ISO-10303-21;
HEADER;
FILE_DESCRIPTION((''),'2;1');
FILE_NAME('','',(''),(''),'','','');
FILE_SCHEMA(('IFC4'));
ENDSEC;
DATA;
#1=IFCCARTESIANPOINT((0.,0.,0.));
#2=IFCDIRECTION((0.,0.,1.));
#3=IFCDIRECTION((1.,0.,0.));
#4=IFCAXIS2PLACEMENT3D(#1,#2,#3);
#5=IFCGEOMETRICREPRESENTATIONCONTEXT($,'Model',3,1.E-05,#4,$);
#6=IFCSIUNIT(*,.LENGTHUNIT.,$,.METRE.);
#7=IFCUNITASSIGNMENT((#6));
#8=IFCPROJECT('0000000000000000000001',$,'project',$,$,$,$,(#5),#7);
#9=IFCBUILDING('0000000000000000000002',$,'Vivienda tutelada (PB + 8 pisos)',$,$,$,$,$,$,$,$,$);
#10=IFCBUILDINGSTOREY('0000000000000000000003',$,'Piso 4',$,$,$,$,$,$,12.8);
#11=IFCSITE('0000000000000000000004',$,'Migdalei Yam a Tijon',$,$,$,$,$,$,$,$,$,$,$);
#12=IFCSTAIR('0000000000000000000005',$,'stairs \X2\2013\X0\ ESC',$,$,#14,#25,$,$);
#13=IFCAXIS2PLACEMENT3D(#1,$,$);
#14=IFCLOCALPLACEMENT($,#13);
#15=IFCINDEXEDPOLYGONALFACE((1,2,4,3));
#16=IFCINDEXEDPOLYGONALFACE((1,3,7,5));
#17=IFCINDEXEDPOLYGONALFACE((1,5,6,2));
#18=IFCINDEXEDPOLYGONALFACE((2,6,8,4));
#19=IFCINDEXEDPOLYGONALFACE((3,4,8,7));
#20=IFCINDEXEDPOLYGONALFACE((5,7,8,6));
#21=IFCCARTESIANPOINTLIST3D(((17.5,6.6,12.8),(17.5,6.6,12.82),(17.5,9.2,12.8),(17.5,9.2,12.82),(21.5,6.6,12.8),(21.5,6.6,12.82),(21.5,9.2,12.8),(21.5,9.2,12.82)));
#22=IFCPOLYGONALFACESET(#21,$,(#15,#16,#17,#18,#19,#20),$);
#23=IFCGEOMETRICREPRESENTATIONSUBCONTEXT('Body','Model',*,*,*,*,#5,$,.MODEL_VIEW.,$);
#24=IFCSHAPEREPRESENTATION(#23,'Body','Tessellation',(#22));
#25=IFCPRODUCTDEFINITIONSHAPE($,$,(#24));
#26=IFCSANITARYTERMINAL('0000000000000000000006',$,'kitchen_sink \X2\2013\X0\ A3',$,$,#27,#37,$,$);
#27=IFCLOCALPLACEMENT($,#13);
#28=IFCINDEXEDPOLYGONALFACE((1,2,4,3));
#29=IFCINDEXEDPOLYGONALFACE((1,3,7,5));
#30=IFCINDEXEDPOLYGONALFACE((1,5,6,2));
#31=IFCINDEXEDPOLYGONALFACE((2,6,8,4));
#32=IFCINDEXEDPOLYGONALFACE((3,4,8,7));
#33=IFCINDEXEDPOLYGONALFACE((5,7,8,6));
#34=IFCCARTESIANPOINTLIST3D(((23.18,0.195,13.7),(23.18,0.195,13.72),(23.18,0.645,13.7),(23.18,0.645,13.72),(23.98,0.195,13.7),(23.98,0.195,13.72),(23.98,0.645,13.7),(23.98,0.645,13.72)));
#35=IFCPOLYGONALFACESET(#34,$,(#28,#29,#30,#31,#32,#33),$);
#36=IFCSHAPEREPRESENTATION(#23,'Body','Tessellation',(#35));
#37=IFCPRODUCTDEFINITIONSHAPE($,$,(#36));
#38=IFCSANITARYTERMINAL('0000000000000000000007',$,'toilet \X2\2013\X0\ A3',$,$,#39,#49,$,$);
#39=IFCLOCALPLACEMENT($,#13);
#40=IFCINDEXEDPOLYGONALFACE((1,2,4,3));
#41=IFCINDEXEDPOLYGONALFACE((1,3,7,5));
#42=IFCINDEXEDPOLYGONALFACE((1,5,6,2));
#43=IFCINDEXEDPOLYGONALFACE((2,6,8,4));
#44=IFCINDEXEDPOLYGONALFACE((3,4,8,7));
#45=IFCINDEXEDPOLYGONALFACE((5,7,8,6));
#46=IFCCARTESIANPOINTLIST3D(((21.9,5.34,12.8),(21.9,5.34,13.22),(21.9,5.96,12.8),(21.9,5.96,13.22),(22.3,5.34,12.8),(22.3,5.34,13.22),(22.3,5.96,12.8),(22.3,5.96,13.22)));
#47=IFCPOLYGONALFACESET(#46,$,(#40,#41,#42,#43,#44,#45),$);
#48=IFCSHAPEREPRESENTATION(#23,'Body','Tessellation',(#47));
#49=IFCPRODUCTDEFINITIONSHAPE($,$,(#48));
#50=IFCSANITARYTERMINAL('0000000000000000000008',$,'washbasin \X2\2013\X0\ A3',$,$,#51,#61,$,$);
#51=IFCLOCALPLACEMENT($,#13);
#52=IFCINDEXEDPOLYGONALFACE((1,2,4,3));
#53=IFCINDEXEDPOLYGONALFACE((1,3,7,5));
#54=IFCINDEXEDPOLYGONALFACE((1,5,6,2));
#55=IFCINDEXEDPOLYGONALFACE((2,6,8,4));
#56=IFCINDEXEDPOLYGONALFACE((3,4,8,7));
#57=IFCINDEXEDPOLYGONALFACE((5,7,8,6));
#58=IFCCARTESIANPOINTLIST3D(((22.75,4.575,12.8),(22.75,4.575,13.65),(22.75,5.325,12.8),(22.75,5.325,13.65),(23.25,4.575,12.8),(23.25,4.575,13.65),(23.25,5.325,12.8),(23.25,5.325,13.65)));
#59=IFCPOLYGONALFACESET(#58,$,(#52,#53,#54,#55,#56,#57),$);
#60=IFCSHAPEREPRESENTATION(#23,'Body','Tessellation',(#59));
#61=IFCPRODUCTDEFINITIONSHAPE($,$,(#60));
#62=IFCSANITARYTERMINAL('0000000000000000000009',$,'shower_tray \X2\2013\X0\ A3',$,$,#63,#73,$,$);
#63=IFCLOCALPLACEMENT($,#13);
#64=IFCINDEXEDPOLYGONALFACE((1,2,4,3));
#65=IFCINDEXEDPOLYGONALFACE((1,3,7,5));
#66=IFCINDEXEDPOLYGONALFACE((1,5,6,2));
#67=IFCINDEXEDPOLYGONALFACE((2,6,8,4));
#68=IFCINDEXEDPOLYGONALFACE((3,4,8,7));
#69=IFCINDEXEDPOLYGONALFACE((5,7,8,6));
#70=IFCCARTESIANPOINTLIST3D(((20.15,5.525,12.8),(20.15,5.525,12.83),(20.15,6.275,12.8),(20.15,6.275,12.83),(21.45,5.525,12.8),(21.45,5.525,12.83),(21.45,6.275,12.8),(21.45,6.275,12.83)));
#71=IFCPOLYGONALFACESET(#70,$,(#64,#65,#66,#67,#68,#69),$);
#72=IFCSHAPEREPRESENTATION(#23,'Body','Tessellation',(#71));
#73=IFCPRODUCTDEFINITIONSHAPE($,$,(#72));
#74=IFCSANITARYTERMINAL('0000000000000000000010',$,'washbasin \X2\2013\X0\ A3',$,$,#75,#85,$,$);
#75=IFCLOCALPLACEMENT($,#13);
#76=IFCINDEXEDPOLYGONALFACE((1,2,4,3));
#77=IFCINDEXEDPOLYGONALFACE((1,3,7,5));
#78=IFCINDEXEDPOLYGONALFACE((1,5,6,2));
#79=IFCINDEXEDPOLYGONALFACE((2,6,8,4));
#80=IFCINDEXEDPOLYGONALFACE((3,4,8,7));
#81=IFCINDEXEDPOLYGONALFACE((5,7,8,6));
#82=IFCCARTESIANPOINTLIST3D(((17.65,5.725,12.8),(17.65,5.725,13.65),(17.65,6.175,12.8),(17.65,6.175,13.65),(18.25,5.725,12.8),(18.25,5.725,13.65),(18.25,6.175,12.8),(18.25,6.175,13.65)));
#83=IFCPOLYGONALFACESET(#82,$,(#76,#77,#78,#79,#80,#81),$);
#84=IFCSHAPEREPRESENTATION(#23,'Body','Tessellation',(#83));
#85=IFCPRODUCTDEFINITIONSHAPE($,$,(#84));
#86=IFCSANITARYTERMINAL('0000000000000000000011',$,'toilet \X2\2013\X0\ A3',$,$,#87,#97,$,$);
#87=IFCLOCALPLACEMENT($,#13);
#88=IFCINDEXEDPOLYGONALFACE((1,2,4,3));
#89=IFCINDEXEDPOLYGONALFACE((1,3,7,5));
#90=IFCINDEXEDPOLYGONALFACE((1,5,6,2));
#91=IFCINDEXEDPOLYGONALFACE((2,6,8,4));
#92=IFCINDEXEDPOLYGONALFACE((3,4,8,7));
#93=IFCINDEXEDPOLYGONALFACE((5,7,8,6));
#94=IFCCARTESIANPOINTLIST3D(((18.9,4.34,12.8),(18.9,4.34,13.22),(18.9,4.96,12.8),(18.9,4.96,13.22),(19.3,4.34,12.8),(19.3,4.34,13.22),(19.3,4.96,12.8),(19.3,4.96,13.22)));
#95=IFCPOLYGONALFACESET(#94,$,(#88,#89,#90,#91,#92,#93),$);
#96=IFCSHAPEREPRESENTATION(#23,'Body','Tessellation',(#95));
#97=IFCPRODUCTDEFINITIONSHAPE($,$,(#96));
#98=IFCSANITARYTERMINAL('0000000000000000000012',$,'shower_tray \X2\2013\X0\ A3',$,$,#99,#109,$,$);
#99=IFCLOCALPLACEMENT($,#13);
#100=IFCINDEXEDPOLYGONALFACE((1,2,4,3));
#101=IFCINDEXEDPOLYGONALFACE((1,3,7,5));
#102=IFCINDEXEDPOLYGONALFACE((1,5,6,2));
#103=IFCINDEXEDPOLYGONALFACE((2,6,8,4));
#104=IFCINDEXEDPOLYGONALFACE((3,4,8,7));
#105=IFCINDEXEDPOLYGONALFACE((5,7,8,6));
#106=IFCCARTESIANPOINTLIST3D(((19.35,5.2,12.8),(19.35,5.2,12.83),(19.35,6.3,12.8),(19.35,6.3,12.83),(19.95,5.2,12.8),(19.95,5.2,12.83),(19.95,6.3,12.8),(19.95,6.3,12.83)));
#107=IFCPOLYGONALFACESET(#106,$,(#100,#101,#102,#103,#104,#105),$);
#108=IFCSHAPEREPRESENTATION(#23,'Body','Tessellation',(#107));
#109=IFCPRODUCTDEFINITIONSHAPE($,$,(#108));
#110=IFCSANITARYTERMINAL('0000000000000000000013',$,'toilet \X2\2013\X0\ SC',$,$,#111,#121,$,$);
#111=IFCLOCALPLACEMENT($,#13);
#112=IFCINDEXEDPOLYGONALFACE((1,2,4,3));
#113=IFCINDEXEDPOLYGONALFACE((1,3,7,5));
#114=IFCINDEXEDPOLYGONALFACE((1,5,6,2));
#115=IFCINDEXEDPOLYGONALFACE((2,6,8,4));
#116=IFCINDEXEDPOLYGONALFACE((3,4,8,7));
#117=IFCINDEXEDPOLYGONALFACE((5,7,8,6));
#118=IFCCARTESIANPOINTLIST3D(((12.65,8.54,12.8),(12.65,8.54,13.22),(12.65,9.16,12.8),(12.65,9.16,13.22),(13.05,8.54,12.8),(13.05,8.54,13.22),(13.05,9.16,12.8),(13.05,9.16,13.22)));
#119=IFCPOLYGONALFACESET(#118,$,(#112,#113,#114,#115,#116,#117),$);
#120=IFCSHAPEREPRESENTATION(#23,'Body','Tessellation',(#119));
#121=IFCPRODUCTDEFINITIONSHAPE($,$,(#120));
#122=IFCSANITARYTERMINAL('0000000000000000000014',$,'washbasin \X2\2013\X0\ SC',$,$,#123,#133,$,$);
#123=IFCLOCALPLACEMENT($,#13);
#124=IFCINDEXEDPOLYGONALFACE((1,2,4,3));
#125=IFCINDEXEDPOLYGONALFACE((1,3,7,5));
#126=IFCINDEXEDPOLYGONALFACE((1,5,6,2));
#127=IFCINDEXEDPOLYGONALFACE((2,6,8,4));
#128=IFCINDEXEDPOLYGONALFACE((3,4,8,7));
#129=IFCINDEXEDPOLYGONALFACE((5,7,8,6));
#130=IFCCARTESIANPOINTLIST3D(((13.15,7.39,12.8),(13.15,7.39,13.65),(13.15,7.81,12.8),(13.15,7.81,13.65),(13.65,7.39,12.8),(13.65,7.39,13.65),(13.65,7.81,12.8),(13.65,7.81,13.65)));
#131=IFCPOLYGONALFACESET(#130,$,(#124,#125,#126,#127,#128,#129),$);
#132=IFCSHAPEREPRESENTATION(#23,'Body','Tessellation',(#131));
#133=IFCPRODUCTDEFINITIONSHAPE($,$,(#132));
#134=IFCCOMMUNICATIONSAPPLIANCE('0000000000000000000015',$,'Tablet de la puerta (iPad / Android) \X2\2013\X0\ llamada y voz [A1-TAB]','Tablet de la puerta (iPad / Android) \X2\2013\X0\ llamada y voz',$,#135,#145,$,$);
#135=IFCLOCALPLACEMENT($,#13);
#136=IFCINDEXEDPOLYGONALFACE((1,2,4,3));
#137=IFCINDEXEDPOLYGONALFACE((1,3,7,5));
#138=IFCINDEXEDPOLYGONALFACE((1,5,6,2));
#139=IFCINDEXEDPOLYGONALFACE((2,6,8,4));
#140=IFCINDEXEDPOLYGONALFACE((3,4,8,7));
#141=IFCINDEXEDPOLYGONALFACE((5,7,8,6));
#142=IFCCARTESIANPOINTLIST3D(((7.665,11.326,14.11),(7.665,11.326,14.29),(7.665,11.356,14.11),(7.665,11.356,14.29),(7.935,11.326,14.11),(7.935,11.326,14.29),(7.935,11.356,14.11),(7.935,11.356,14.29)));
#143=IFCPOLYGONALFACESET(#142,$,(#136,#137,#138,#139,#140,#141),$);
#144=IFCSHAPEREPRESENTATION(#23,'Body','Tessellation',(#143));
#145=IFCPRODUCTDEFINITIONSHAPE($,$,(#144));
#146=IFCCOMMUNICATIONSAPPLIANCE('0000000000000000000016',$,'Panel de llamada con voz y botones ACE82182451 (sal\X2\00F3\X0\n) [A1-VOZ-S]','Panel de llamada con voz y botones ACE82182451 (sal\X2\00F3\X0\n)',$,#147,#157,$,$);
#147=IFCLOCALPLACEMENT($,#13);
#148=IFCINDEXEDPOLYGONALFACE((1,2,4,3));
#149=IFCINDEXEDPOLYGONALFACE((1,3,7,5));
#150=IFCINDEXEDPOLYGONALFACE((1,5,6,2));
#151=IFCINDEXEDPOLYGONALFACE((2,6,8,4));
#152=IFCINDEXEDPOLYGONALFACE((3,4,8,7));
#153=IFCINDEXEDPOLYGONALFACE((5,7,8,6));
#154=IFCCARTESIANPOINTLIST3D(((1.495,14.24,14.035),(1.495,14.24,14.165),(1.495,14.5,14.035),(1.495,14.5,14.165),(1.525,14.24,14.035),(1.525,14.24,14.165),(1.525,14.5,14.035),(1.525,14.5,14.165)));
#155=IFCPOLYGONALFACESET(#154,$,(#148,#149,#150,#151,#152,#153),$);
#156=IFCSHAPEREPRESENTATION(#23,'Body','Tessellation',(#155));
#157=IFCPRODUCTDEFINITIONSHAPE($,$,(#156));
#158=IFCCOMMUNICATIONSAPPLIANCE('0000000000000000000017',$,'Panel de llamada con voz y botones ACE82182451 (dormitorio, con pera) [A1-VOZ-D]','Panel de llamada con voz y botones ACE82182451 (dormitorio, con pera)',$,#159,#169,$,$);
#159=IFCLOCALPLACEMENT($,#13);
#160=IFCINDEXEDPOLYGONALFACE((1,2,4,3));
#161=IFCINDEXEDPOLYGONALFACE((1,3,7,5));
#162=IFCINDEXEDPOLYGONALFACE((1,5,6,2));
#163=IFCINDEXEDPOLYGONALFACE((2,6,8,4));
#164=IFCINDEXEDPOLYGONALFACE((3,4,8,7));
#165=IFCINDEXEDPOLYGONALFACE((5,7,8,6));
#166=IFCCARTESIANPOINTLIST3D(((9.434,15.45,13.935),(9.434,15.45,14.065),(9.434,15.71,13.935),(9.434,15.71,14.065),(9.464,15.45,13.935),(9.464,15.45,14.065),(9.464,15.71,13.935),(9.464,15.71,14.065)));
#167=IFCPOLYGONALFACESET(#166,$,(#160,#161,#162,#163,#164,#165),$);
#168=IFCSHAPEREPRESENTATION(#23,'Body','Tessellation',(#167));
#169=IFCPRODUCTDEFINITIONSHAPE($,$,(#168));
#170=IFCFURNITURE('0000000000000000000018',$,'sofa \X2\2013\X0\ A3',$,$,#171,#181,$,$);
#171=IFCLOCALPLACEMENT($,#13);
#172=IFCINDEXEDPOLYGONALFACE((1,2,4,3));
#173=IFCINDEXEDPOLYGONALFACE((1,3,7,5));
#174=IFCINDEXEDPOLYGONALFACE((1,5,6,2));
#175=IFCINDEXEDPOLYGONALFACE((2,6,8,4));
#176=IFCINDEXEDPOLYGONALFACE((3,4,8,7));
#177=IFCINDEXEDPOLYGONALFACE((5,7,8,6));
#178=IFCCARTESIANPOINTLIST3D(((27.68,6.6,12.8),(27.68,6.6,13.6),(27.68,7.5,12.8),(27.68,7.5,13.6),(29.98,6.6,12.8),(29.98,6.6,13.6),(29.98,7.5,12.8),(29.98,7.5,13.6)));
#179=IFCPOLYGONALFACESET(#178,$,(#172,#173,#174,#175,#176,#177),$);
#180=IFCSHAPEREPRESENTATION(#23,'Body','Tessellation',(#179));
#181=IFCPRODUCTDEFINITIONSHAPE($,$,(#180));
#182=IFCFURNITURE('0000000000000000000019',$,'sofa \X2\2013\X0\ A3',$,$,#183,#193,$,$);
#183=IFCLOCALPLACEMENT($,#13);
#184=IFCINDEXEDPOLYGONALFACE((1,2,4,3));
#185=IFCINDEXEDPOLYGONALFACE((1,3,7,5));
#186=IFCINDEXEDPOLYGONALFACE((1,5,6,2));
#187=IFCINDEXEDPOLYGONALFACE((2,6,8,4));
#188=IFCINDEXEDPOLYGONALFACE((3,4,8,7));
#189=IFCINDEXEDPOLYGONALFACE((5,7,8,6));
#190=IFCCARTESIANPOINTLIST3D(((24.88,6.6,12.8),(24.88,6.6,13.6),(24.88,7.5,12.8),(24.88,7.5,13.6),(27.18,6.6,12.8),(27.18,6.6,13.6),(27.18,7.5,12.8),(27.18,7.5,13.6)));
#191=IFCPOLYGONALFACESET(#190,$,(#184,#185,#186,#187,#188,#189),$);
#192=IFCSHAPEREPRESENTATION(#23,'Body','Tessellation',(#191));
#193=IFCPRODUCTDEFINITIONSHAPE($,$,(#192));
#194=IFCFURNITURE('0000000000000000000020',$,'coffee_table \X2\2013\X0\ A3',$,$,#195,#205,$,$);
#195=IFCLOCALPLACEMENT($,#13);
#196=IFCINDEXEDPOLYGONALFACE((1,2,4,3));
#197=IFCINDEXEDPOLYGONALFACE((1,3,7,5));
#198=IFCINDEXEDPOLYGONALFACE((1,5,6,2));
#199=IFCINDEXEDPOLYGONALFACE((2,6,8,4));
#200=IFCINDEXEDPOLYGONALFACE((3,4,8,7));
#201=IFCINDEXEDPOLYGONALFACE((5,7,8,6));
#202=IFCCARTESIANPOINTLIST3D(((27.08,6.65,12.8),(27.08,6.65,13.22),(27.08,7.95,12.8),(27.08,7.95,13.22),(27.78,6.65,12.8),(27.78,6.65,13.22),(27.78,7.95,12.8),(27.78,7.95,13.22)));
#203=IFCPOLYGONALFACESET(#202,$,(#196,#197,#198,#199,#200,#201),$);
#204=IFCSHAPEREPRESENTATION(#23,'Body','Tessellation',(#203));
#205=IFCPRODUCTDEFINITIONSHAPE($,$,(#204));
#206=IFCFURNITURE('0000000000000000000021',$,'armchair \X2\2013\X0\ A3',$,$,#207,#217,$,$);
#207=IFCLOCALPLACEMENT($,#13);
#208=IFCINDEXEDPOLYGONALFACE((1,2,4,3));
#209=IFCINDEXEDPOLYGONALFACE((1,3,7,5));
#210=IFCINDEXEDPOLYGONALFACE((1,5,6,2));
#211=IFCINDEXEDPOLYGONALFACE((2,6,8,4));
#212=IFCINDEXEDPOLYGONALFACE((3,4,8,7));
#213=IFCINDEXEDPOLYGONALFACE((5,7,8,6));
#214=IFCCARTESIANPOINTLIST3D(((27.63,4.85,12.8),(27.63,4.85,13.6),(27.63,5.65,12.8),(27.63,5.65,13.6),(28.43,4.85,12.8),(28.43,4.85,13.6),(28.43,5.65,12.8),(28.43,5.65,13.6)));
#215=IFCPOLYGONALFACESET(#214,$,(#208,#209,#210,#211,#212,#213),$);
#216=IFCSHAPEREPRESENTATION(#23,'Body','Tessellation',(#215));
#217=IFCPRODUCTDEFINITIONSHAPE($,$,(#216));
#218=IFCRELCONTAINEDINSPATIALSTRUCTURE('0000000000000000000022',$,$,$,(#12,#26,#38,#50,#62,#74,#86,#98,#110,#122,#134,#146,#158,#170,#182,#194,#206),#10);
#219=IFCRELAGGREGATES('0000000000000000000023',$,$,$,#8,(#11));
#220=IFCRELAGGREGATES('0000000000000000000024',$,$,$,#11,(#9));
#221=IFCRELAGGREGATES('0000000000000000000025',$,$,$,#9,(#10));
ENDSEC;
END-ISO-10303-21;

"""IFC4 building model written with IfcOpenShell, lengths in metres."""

from ifc_helpers import new_model, si_unit, frame, origin_with_axes, context, subcontext, project, spatial, line, indexed_curve, outline, extrude, element, save


model = new_model("IFC4")

# Units and contexts
model_context = context("Model", 3, precision=1e-05, world=origin_with_axes())
body_context = subcontext(model_context, "Body", "Model", "MODEL_VIEW")
ifc_project = project(units=[si_unit("LENGTHUNIT", "METRE")], contexts=[model_context])

# Site, building, storey
site = spatial("IfcSite", under=ifc_project, Name="Migdalei Yam a Tijon")
building = spatial("IfcBuilding", under=site, Name="Vivienda tutelada (PB + 8 pisos)")
storey = spatial("IfcBuildingStorey", under=building, Name="Piso 4", Elevation=12.8)

# Stair
element("IfcStair", 1, inside=storey, Name="stairs – ESC", context=body_context, shape_type="SweptSolid", body=[
    extrude(outline(indexed_curve([(0.0, 0.0), (4.0, 0.0), (4.0, 2.6), (0.0, 2.6)], segments=[line(1, 2, 3, 4, 1)])), frame((17.5, 6.6, 12.8), z_axis=(0.0, 0.0, 1.0), x_axis=(1.0, 0.0, 0.0)), (0.0, 0.0, 1.0), 0.02),
])

# Sanitary terminals
element("IfcSanitaryTerminal", 2, inside=storey, Name="kitchen_sink – A3", context=body_context, shape_type="SweptSolid", body=[
    extrude(outline(indexed_curve([(0.0, 0.0), (0.8, 0.0), (0.8, 0.45), (0.0, 0.45)], segments=[line(1, 2, 3, 4, 1)])), frame((23.18, 0.195, 13.7), z_axis=(0.0, 0.0, 1.0), x_axis=(1.0, 0.0, 0.0)), (0.0, 0.0, 1.0), 0.02),
])
element("IfcSanitaryTerminal", 3, inside=storey, Name="toilet – A3", context=body_context, shape_type="SweptSolid", body=[
    extrude(outline(indexed_curve([(0.0, 0.0), (0.4, 0.0), (0.4, 0.62), (0.0, 0.62)], segments=[line(1, 2, 3, 4, 1)])), frame((21.9, 5.34, 12.8), z_axis=(0.0, 0.0, 1.0), x_axis=(1.0, 0.0, 0.0)), (0.0, 0.0, 1.0), 0.42),
])
element("IfcSanitaryTerminal", 4, inside=storey, Name="washbasin – A3", context=body_context, shape_type="SweptSolid", body=[
    extrude(outline(indexed_curve([(0.0, 0.0), (0.5, 0.0), (0.5, 0.75), (0.0, 0.75)], segments=[line(1, 2, 3, 4, 1)])), frame((22.75, 4.575, 12.8), z_axis=(0.0, 0.0, 1.0), x_axis=(1.0, 0.0, 0.0)), (0.0, 0.0, 1.0), 0.85),
])
element("IfcSanitaryTerminal", 5, inside=storey, Name="shower_tray – A3", context=body_context, shape_type="SweptSolid", body=[
    extrude(outline(indexed_curve([(0.0, 0.0), (1.3, 0.0), (1.3, 0.75), (0.0, 0.75)], segments=[line(1, 2, 3, 4, 1)])), frame((20.15, 5.525, 12.8), z_axis=(0.0, 0.0, 1.0), x_axis=(1.0, 0.0, 0.0)), (0.0, 0.0, 1.0), 0.03),
])
element("IfcSanitaryTerminal", 6, inside=storey, Name="washbasin – A3", context=body_context, shape_type="SweptSolid", body=[
    extrude(outline(indexed_curve([(0.0, 0.0), (0.6, 0.0), (0.6, 0.45), (0.0, 0.45)], segments=[line(1, 2, 3, 4, 1)])), frame((17.65, 5.725, 12.8), z_axis=(0.0, 0.0, 1.0), x_axis=(1.0, 0.0, 0.0)), (0.0, 0.0, 1.0), 0.85),
])
element("IfcSanitaryTerminal", 7, inside=storey, Name="toilet – A3", context=body_context, shape_type="SweptSolid", body=[
    extrude(outline(indexed_curve([(0.0, 0.0), (0.4, 0.0), (0.4, 0.62), (0.0, 0.62)], segments=[line(1, 2, 3, 4, 1)])), frame((18.9, 4.34, 12.8), z_axis=(0.0, 0.0, 1.0), x_axis=(1.0, 0.0, 0.0)), (0.0, 0.0, 1.0), 0.42),
])
element("IfcSanitaryTerminal", 8, inside=storey, Name="shower_tray – A3", context=body_context, shape_type="SweptSolid", body=[
    extrude(outline(indexed_curve([(0.0, 0.0), (0.6, 0.0), (0.6, 1.1), (0.0, 1.1)], segments=[line(1, 2, 3, 4, 1)])), frame((19.35, 5.2, 12.8), z_axis=(0.0, 0.0, 1.0), x_axis=(1.0, 0.0, 0.0)), (0.0, 0.0, 1.0), 0.03),
])
element("IfcSanitaryTerminal", 9, inside=storey, Name="toilet – SC", context=body_context, shape_type="SweptSolid", body=[
    extrude(outline(indexed_curve([(0.0, 0.0), (0.4, 0.0), (0.4, 0.62), (0.0, 0.62)], segments=[line(1, 2, 3, 4, 1)])), frame((12.65, 8.54, 12.8), z_axis=(0.0, 0.0, 1.0), x_axis=(1.0, 0.0, 0.0)), (0.0, 0.0, 1.0), 0.42),
])
element("IfcSanitaryTerminal", 10, inside=storey, Name="washbasin – SC", context=body_context, shape_type="SweptSolid", body=[
    extrude(outline(indexed_curve([(0.0, 0.0), (0.5, 0.0), (0.5, 0.42), (0.0, 0.42)], segments=[line(1, 2, 3, 4, 1)])), frame((13.15, 7.39, 12.8), z_axis=(0.0, 0.0, 1.0), x_axis=(1.0, 0.0, 0.0)), (0.0, 0.0, 1.0), 0.85),
])

# Communications appliances
element("IfcCommunicationsAppliance", 11, inside=storey, Name="Tablet de la puerta (iPad / Android) – llamada y voz [A1-TAB]", Description="Tablet de la puerta (iPad / Android) – llamada y voz", context=body_context, shape_type="SweptSolid", body=[
    extrude(outline(indexed_curve([(0.0, 0.0), (0.27, 0.0), (0.27, 0.03), (0.0, 0.03)], segments=[line(1, 2, 3, 4, 1)])), frame((7.665, 11.326, 14.11), z_axis=(0.0, 0.0, 1.0), x_axis=(1.0, 0.0, 0.0)), (0.0, 0.0, 1.0), 0.18),
])
element("IfcCommunicationsAppliance", 12, inside=storey, Name="Panel de llamada con voz y botones ACE82182451 (salón) [A1-VOZ-S]", Description="Panel de llamada con voz y botones ACE82182451 (salón)", context=body_context, shape_type="SweptSolid", body=[
    extrude(outline(indexed_curve([(0.0, 0.0), (0.03, 0.0), (0.03, 0.26), (0.0, 0.26)], segments=[line(1, 2, 3, 4, 1)])), frame((1.495, 14.24, 14.035), z_axis=(0.0, 0.0, 1.0), x_axis=(1.0, 0.0, 0.0)), (0.0, 0.0, 1.0), 0.13),
])
element("IfcCommunicationsAppliance", 13, inside=storey, Name="Panel de llamada con voz y botones ACE82182451 (dormitorio, con pera) [A1-VOZ-D]", Description="Panel de llamada con voz y botones ACE82182451 (dormitorio, con pera)", context=body_context, shape_type="SweptSolid", body=[
    extrude(outline(indexed_curve([(0.0, 0.0), (0.03, 0.0), (0.03, 0.26), (0.0, 0.26)], segments=[line(1, 2, 3, 4, 1)])), frame((9.434, 15.45, 13.935), z_axis=(0.0, 0.0, 1.0), x_axis=(1.0, 0.0, 0.0)), (0.0, 0.0, 1.0), 0.13),
])

# Furniture
element("IfcFurniture", 14, inside=storey, Name="sofa – A3", context=body_context, shape_type="SweptSolid", body=[
    extrude(outline(indexed_curve([(0.0, 0.0), (2.3, 0.0), (2.3, 0.9), (0.0, 0.9)], segments=[line(1, 2, 3, 4, 1)])), frame((27.68, 6.6, 12.8), z_axis=(0.0, 0.0, 1.0), x_axis=(1.0, 0.0, 0.0)), (0.0, 0.0, 1.0), 0.8),
])
element("IfcFurniture", 15, inside=storey, Name="sofa – A3", context=body_context, shape_type="SweptSolid", body=[
    extrude(outline(indexed_curve([(0.0, 0.0), (2.3, 0.0), (2.3, 0.9), (0.0, 0.9)], segments=[line(1, 2, 3, 4, 1)])), frame((24.88, 6.6, 12.8), z_axis=(0.0, 0.0, 1.0), x_axis=(1.0, 0.0, 0.0)), (0.0, 0.0, 1.0), 0.8),
])
element("IfcFurniture", 16, inside=storey, Name="coffee_table – A3", context=body_context, shape_type="SweptSolid", body=[
    extrude(outline(indexed_curve([(0.0, 0.0), (0.7, 0.0), (0.7, 1.3), (0.0, 1.3)], segments=[line(1, 2, 3, 4, 1)])), frame((27.08, 6.65, 12.8), z_axis=(0.0, 0.0, 1.0), x_axis=(1.0, 0.0, 0.0)), (0.0, 0.0, 1.0), 0.42),
])
element("IfcFurniture", 17, inside=storey, Name="armchair – A3", context=body_context, shape_type="SweptSolid", body=[
    extrude(outline(indexed_curve([(0.0, 0.0), (0.8, 0.0), (0.8, 0.8), (0.0, 0.8)], segments=[line(1, 2, 3, 4, 1)])), frame((27.63, 4.85, 12.8), z_axis=(0.0, 0.0, 1.0), x_axis=(1.0, 0.0, 0.0)), (0.0, 0.0, 1.0), 0.8),
])

save(model, "model.ifc")
